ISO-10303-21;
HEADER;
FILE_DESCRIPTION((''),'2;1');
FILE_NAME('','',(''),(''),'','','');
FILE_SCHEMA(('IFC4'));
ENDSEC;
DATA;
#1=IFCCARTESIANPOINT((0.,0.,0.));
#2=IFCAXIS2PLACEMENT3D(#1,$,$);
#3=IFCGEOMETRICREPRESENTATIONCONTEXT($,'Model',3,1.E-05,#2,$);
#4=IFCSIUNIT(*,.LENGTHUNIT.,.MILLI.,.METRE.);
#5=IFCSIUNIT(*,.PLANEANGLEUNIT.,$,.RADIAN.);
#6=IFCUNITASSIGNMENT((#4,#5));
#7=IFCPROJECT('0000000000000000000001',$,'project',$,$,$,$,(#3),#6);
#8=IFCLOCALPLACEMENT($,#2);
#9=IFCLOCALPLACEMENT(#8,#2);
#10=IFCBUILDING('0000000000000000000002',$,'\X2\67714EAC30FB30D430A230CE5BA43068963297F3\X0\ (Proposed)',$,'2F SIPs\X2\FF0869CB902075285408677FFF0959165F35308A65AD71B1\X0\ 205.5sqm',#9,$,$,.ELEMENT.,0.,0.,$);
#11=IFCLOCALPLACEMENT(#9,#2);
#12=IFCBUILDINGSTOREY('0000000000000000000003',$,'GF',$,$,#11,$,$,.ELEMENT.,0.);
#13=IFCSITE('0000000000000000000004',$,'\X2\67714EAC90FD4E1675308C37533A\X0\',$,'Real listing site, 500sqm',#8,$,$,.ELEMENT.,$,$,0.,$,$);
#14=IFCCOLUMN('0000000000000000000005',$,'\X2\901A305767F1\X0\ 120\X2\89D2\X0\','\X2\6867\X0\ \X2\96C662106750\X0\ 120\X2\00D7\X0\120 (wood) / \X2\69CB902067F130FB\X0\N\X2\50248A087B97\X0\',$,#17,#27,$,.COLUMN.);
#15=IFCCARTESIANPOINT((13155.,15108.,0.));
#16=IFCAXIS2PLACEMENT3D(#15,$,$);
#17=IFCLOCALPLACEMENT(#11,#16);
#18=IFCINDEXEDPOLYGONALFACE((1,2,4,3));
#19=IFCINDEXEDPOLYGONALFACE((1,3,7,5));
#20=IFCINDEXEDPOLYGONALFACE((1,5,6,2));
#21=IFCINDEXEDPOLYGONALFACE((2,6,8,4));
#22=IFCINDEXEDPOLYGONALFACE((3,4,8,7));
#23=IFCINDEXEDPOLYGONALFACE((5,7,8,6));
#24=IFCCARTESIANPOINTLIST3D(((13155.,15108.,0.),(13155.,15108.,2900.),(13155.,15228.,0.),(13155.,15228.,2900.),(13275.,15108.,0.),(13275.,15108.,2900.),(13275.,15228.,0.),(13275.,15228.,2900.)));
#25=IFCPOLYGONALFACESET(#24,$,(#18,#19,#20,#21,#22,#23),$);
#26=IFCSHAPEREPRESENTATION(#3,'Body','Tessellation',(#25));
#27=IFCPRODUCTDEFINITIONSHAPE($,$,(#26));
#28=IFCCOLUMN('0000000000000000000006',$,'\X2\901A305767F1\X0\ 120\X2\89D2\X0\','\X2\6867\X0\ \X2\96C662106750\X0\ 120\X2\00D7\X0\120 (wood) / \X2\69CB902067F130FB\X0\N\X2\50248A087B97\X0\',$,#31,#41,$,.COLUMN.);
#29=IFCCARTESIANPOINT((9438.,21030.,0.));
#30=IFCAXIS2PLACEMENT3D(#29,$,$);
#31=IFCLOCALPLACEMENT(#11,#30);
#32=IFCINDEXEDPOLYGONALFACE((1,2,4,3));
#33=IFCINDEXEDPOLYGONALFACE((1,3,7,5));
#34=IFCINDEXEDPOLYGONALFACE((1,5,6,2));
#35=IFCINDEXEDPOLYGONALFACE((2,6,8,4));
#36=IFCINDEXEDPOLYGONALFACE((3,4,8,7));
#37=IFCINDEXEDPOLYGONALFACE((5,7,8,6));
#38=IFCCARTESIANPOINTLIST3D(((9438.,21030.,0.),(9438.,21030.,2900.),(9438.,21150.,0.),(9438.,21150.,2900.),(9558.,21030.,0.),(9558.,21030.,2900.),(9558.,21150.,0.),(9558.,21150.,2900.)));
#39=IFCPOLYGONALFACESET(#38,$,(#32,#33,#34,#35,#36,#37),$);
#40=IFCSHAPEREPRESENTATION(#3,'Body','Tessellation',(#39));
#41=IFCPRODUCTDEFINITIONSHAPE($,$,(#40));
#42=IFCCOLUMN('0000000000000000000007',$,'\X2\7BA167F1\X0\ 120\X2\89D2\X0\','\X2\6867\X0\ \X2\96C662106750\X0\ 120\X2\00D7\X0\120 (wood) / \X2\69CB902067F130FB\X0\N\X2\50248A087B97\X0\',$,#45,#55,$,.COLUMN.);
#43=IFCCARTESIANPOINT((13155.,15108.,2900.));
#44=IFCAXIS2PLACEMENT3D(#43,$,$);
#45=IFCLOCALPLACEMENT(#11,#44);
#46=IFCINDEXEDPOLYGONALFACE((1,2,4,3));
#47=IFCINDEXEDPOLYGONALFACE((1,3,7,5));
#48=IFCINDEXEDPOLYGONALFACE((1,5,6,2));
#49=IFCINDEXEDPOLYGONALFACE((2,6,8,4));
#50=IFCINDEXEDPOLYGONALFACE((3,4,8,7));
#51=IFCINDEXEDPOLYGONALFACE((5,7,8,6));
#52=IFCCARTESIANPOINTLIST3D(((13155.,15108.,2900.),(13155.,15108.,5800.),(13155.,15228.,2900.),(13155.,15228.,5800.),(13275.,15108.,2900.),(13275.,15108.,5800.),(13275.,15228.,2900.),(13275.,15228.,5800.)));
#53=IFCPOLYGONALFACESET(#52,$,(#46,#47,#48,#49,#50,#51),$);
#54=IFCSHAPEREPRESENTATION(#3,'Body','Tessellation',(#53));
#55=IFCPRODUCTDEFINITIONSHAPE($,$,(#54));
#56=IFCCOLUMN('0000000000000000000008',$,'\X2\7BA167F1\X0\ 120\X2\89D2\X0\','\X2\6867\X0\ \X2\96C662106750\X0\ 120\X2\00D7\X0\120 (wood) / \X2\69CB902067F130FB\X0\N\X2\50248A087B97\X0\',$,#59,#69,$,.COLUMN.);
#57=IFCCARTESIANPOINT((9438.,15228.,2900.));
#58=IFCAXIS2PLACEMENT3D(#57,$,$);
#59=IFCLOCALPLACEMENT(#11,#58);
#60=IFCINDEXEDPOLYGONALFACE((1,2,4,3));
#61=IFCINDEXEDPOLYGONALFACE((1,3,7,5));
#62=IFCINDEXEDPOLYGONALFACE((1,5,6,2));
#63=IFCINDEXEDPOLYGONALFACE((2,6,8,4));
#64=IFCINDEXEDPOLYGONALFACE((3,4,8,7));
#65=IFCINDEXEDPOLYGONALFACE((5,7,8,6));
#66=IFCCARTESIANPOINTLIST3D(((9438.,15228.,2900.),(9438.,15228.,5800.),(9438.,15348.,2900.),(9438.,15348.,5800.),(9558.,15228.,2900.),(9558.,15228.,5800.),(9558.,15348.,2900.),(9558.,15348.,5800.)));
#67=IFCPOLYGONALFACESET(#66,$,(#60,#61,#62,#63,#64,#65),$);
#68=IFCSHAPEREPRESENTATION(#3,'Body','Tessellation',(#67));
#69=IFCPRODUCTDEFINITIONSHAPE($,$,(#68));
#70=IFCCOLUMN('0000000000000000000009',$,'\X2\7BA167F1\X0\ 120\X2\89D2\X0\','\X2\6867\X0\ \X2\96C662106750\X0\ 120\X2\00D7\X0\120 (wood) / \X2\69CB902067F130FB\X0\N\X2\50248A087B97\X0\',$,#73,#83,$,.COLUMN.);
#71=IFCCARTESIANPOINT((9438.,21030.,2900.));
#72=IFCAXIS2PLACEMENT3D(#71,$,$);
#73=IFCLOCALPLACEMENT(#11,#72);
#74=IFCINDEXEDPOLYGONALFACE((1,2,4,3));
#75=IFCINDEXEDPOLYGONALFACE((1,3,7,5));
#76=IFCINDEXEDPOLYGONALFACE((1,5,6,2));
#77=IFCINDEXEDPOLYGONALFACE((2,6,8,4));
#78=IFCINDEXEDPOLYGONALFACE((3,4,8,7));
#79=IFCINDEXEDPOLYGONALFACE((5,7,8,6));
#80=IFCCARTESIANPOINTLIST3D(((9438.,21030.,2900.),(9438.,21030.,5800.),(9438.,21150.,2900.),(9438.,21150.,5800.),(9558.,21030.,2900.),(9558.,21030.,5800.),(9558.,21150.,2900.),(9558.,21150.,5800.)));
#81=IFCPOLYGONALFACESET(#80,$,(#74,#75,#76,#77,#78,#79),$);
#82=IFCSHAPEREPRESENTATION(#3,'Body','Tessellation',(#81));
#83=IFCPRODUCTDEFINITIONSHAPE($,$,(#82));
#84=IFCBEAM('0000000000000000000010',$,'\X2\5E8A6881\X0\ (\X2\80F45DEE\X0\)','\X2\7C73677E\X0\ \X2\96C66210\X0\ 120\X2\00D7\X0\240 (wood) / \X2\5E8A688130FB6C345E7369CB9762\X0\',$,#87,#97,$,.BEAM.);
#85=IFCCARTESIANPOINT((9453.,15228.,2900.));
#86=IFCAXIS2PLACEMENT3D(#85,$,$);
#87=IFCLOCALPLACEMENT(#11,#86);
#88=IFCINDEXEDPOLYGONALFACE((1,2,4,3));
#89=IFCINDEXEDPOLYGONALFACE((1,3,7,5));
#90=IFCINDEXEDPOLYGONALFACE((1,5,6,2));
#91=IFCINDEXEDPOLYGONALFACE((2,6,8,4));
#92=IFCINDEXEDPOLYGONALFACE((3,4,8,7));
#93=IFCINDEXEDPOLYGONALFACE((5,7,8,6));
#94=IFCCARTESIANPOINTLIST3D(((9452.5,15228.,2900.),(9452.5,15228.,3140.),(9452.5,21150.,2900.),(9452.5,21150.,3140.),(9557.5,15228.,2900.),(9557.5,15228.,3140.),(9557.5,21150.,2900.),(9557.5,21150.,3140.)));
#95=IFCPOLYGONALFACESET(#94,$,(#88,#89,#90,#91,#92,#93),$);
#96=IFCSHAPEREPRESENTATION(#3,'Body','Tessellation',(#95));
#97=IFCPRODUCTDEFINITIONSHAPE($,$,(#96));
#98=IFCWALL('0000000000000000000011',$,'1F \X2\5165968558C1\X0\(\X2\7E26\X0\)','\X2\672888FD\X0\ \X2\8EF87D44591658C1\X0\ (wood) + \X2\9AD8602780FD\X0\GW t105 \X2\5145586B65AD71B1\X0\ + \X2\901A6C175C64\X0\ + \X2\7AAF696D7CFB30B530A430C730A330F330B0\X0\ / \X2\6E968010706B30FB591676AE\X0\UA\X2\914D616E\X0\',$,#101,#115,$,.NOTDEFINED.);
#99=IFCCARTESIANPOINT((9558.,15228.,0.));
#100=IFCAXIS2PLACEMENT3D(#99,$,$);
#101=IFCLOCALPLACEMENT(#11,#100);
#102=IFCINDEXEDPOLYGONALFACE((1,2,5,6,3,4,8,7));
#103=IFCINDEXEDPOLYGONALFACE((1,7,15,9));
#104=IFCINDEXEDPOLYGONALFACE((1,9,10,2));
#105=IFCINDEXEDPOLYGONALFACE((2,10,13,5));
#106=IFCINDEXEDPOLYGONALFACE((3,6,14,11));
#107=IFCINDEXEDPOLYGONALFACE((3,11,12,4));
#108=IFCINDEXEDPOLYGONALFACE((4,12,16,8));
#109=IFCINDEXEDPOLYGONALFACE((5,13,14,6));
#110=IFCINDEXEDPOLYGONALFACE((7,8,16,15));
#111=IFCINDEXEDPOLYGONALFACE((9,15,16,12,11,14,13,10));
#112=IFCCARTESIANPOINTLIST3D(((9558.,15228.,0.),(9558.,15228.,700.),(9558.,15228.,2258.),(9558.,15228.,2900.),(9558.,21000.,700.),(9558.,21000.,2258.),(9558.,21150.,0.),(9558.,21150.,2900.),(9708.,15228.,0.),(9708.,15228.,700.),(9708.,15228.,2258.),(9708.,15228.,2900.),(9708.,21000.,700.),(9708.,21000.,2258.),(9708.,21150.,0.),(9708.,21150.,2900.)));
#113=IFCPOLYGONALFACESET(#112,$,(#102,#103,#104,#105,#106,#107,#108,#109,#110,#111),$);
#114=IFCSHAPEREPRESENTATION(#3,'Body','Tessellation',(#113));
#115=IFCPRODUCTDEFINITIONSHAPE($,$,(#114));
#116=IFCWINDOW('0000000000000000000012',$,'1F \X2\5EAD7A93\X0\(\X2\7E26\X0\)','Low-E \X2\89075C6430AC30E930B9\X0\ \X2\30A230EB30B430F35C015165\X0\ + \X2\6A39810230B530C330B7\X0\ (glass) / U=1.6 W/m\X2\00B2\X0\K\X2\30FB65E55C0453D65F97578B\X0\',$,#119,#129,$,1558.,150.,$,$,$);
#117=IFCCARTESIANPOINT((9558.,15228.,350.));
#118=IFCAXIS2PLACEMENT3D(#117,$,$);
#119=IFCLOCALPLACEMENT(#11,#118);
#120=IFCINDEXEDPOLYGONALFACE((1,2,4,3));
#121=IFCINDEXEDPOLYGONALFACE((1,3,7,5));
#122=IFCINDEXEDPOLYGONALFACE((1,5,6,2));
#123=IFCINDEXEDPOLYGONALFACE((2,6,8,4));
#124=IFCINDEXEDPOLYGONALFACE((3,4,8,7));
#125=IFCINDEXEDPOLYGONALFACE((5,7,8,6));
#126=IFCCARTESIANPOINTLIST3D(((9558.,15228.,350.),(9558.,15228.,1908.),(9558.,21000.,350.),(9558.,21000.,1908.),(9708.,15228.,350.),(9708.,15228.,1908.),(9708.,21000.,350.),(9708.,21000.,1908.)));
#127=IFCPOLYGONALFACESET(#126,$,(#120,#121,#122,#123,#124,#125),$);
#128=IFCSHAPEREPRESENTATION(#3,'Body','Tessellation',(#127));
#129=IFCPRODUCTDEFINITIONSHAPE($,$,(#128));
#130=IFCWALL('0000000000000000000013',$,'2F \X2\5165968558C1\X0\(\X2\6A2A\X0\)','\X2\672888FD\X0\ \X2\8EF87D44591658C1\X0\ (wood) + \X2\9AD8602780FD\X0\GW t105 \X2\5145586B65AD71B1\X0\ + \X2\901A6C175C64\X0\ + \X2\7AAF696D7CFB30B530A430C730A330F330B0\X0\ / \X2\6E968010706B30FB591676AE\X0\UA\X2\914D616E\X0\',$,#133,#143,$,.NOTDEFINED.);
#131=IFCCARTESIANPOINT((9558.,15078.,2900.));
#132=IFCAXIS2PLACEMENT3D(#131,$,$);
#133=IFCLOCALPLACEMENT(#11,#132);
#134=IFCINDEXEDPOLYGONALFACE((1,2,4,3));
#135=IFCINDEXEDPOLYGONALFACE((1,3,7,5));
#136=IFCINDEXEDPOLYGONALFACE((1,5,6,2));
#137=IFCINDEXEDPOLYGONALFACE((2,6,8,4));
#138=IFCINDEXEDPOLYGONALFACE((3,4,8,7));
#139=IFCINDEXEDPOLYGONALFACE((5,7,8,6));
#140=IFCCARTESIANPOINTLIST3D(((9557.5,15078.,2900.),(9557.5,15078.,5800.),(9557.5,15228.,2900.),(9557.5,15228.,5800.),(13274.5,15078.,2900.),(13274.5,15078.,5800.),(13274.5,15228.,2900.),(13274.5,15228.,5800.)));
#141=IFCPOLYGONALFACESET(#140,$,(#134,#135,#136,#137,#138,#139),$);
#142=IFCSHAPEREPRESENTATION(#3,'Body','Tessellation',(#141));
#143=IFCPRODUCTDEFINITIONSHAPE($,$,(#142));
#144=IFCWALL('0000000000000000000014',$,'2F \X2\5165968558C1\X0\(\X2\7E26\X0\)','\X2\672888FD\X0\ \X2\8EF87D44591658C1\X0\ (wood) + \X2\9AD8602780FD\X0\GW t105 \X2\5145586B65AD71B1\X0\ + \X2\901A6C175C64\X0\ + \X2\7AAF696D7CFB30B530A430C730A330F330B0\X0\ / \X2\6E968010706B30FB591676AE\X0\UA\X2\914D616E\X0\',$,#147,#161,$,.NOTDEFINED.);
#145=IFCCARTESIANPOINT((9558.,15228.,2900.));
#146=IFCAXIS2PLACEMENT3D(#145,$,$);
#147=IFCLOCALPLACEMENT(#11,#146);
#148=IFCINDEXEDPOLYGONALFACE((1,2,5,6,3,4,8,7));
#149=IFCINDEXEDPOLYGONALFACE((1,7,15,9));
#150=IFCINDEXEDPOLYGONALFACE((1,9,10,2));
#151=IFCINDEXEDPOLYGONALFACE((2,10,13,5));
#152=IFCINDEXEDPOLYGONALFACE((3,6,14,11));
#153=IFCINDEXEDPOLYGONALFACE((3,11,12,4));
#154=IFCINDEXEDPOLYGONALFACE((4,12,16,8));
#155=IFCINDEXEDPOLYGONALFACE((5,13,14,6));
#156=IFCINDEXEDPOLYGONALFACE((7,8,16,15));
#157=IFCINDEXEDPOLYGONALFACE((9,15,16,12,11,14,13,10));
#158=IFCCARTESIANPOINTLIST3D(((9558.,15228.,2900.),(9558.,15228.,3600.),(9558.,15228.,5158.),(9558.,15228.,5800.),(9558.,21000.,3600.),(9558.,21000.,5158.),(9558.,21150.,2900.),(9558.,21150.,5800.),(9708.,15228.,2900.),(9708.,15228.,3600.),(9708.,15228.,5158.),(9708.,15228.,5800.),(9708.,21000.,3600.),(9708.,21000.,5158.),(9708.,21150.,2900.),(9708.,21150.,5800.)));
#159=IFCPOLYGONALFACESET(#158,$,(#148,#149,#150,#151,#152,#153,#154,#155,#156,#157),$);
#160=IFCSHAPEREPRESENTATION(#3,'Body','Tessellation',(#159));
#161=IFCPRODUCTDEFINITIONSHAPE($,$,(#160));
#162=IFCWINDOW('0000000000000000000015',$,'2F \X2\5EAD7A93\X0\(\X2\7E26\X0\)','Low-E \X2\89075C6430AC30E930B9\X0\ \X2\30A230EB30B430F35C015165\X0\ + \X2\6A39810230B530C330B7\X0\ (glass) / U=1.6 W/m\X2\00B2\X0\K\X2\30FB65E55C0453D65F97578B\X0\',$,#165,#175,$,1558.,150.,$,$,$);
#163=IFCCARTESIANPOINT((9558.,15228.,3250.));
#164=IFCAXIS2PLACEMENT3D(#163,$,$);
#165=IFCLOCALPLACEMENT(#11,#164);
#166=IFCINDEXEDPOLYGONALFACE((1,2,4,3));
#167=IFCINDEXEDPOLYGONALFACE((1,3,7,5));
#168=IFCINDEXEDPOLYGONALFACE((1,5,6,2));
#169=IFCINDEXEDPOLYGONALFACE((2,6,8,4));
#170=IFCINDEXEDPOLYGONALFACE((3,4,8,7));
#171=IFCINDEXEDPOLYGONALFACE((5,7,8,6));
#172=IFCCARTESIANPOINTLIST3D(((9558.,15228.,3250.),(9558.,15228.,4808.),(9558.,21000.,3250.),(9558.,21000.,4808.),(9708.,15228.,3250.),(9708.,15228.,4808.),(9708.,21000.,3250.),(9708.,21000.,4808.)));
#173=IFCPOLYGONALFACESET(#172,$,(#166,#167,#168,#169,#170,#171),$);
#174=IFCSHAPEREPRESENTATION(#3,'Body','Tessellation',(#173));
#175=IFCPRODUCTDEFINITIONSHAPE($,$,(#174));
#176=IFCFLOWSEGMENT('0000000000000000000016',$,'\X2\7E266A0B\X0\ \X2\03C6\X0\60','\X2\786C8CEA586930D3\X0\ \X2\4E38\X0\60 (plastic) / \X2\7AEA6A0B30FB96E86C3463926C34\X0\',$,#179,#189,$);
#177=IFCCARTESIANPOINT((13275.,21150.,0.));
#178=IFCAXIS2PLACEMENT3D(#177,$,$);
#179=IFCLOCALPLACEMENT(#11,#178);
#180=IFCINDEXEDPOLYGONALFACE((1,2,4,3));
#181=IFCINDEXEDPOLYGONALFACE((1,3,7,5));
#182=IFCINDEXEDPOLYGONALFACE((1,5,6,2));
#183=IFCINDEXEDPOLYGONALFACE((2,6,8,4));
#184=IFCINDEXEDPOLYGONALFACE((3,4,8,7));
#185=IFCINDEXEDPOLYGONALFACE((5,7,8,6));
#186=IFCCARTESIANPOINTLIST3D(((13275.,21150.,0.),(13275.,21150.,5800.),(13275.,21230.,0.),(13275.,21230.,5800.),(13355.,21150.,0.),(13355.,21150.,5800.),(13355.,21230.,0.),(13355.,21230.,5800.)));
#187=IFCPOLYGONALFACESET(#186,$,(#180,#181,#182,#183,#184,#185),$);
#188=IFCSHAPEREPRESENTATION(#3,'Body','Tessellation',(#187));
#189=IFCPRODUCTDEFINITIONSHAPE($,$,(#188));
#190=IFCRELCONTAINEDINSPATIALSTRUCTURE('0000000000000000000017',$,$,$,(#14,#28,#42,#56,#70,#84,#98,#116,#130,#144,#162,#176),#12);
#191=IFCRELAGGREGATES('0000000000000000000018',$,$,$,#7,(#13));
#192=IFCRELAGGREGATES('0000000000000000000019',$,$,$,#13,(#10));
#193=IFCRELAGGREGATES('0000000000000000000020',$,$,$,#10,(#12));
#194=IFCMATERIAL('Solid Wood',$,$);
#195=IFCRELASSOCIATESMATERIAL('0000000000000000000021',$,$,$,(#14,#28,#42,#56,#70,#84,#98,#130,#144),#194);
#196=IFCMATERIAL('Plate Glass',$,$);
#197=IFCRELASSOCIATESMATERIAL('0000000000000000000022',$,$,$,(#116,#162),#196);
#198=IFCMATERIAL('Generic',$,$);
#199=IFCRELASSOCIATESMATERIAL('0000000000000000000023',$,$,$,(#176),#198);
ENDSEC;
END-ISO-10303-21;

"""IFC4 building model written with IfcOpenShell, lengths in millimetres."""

from ifc_helpers import new_model, si_unit, frame, frame_2d, origin, place, context, project, spatial, rectangle, extrude, material, element, fill, save


model = new_model("IFC4")

# Units and contexts
model_context = context("Model", 3, precision=1e-05, world=origin())
ifc_project = project(units=[si_unit("LENGTHUNIT", "METRE", prefix="MILLI"), si_unit("PLANEANGLEUNIT", "RADIAN")], contexts=[model_context])

# Site, building, storey
site_placement = place(None, origin())
site = spatial("IfcSite", under=ifc_project, at=site_placement, Name="東京都世田谷区", ObjectType="Real listing site, 500sqm", CompositionType="ELEMENT", RefElevation=0.0)
building_placement = place(site_placement, origin())
building = spatial("IfcBuilding", under=site, at=building_placement, Name="東京・ピアノ室と防音 (Proposed)", ObjectType="2F SIPs（構造用合板）外張り断熱 205.5sqm", CompositionType="ELEMENT", ElevationOfRefHeight=0.0, ElevationOfTerrain=0.0)
storey_placement = place(building_placement, origin())
storey = spatial("IfcBuildingStorey", under=building, at=storey_placement, Name="GF", CompositionType="ELEMENT", Elevation=0.0)

# Columns
ifc_material_1 = material(Name="Solid Wood")
column_1_placement = place(storey_placement, frame((13155.0, 15108.0, 0.0)))
element("IfcColumn", 1, at=column_1_placement, inside=storey, material=ifc_material_1, Name="通し柱 120角", Description="桧 集成材 120×120 (wood) / 構造柱・N値計算", PredefinedType="COLUMN", context=model_context, shape_type="SweptSolid", body=[
    extrude(rectangle(XDim=120.0, YDim=120.0, at=frame_2d((60.0, 60.0))), frame((13155.0, 15108.0, 0.0)), (0.0, 0.0, 1.0), 2900.0),
])
column_2_placement = place(storey_placement, frame((9438.0, 21030.0, 0.0)))
element("IfcColumn", 2, at=column_2_placement, inside=storey, material=ifc_material_1, Name="通し柱 120角", Description="桧 集成材 120×120 (wood) / 構造柱・N値計算", PredefinedType="COLUMN", context=model_context, shape_type="SweptSolid", body=[
    extrude(rectangle(XDim=120.0, YDim=120.0, at=frame_2d((60.0, 60.0))), frame((9438.0, 21030.0, 0.0)), (0.0, 0.0, 1.0), 2900.0),
])
column_3_placement = place(storey_placement, frame((13155.0, 15108.0, 2900.0)))
element("IfcColumn", 3, at=column_3_placement, inside=storey, material=ifc_material_1, Name="管柱 120角", Description="桧 集成材 120×120 (wood) / 構造柱・N値計算", PredefinedType="COLUMN", context=model_context, shape_type="SweptSolid", body=[
    extrude(rectangle(XDim=120.0, YDim=120.0, at=frame_2d((60.0, 60.0))), frame((13155.0, 15108.0, 2900.0)), (0.0, 0.0, 1.0), 2900.0),
])
column_4_placement = place(storey_placement, frame((9438.0, 15228.0, 2900.0)))
element("IfcColumn", 4, at=column_4_placement, inside=storey, material=ifc_material_1, Name="管柱 120角", Description="桧 集成材 120×120 (wood) / 構造柱・N値計算", PredefinedType="COLUMN", context=model_context, shape_type="SweptSolid", body=[
    extrude(rectangle(XDim=120.0, YDim=120.0, at=frame_2d((60.0, 60.0))), frame((9438.0, 15228.0, 2900.0)), (0.0, 0.0, 1.0), 2900.0),
])
column_5_placement = place(storey_placement, frame((9438.0, 21030.0, 2900.0)))
element("IfcColumn", 5, at=column_5_placement, inside=storey, material=ifc_material_1, Name="管柱 120角", Description="桧 集成材 120×120 (wood) / 構造柱・N値計算", PredefinedType="COLUMN", context=model_context, shape_type="SweptSolid", body=[
    extrude(rectangle(XDim=120.0, YDim=120.0, at=frame_2d((60.0, 60.0))), frame((9438.0, 21030.0, 2900.0)), (0.0, 0.0, 1.0), 2900.0),
])

# Beam
beam_1_placement = place(storey_placement, frame((9453.0, 15228.0, 2900.0)))
element("IfcBeam", 6, at=beam_1_placement, inside=storey, material=ifc_material_1, Name="床梁 (胴差)", Description="米松 集成 120×240 (wood) / 床梁・水平構面", PredefinedType="BEAM", context=model_context, shape_type="SweptSolid", body=[
    extrude(rectangle(XDim=105.0, YDim=5922.0, at=frame_2d((52.0, 2961.0))), frame((9453.0, 15228.0, 2900.0)), (0.0, 0.0, 1.0), 240.0),
])

# Wall, opening, window
wall_1_placement = place(storey_placement, frame((9558.0, 15228.0, 0.0)))
wall_1 = element("IfcWall", 7, at=wall_1_placement, inside=storey, material=ifc_material_1, Name="1F 入隅壁(縦)", Description="木製 軸組外壁 (wood) + 高性能GW t105 充填断熱 + 通気層 + 窯業系サイディング / 準耐火・外皮UA配慮", PredefinedType="NOTDEFINED", context=model_context, shape_type="SweptSolid", body=[
    extrude(rectangle(XDim=150.0, YDim=5922.0, at=frame_2d((75.0, 2961.0))), frame((9558.0, 15228.0, 0.0)), (0.0, 0.0, 1.0), 2900.0),
])
opening_1_placement = place(storey_placement, frame((9558.0, 15228.0, 350.0)))
opening_1 = element("IfcOpeningElement", 8, at=opening_1_placement, cuts=wall_1, PredefinedType="NOTDEFINED", context=model_context, shape_type="SweptSolid", body=[
    extrude(rectangle(XDim=150.0, YDim=5772.0, at=frame_2d((75.0, 2886.0))), frame((9558.0, 15228.0, 350.0)), (0.0, 0.0, 1.0), 1558.0),
])
ifc_material_2 = material(Name="Plate Glass")
window_1_placement = place(storey_placement, frame((9558.0, 15228.0, 350.0)))
window_1 = element("IfcWindow", 9, at=window_1_placement, inside=storey, material=ifc_material_2, Name="1F 庭窓(縦)", Description="Low-E 複層ガラス アルゴン封入 + 樹脂サッシ (glass) / U=1.6 W/m²K・日射取得型", OverallHeight=1558.0, OverallWidth=150.0, context=model_context, shape_type="SweptSolid", body=[
    extrude(rectangle(XDim=150.0, YDim=5772.0, at=frame_2d((75.0, 2886.0))), frame((9558.0, 15228.0, 350.0)), (0.0, 0.0, 1.0), 1558.0),
])
fill(opening_1, window_1)

# Wall
wall_2_placement = place(storey_placement, frame((9558.0, 15078.0, 2900.0)))
element("IfcWall", 10, at=wall_2_placement, inside=storey, material=ifc_material_1, Name="2F 入隅壁(横)", Description="木製 軸組外壁 (wood) + 高性能GW t105 充填断熱 + 通気層 + 窯業系サイディング / 準耐火・外皮UA配慮", PredefinedType="NOTDEFINED", context=model_context, shape_type="SweptSolid", body=[
    extrude(rectangle(XDim=3717.0, YDim=150.0, at=frame_2d((1858.0, 75.0))), frame((9558.0, 15078.0, 2900.0)), (0.0, 0.0, 1.0), 2900.0),
])

# Wall, opening, window
wall_3_placement = place(storey_placement, frame((9558.0, 15228.0, 2900.0)))
wall_3 = element("IfcWall", 11, at=wall_3_placement, inside=storey, material=ifc_material_1, Name="2F 入隅壁(縦)", Description="木製 軸組外壁 (wood) + 高性能GW t105 充填断熱 + 通気層 + 窯業系サイディング / 準耐火・外皮UA配慮", PredefinedType="NOTDEFINED", context=model_context, shape_type="SweptSolid", body=[
    extrude(rectangle(XDim=150.0, YDim=5922.0, at=frame_2d((75.0, 2961.0))), frame((9558.0, 15228.0, 2900.0)), (0.0, 0.0, 1.0), 2900.0),
])
opening_2_placement = place(storey_placement, frame((9558.0, 15228.0, 3250.0)))
opening_2 = element("IfcOpeningElement", 12, at=opening_2_placement, cuts=wall_3, PredefinedType="NOTDEFINED", context=model_context, shape_type="SweptSolid", body=[
    extrude(rectangle(XDim=150.0, YDim=5772.0, at=frame_2d((75.0, 2886.0))), frame((9558.0, 15228.0, 3250.0)), (0.0, 0.0, 1.0), 1558.0),
])
window_2_placement = place(storey_placement, frame((9558.0, 15228.0, 3250.0)))
window_2 = element("IfcWindow", 13, at=window_2_placement, inside=storey, material=ifc_material_2, Name="2F 庭窓(縦)", Description="Low-E 複層ガラス アルゴン封入 + 樹脂サッシ (glass) / U=1.6 W/m²K・日射取得型", OverallHeight=1558.0, OverallWidth=150.0, context=model_context, shape_type="SweptSolid", body=[
    extrude(rectangle(XDim=150.0, YDim=5772.0, at=frame_2d((75.0, 2886.0))), frame((9558.0, 15228.0, 3250.0)), (0.0, 0.0, 1.0), 1558.0),
])
fill(opening_2, window_2)

# Flow segment
ifc_material_3 = material(Name="Generic")
flow_segment_placement = place(storey_placement, frame((13275.0, 21150.0, 0.0)))
element("IfcFlowSegment", 14, at=flow_segment_placement, inside=storey, material=ifc_material_3, Name="縦樋 φ60", Description="硬質塩ビ 丸60 (plastic) / 竪樋・雨水排水", context=model_context, shape_type="SweptSolid", body=[
    extrude(rectangle(XDim=80.0, YDim=80.0, at=frame_2d((40.0, 40.0))), frame((13275.0, 21150.0, 0.0)), (0.0, 0.0, 1.0), 5800.0),
])

save(model, "model.ifc")
